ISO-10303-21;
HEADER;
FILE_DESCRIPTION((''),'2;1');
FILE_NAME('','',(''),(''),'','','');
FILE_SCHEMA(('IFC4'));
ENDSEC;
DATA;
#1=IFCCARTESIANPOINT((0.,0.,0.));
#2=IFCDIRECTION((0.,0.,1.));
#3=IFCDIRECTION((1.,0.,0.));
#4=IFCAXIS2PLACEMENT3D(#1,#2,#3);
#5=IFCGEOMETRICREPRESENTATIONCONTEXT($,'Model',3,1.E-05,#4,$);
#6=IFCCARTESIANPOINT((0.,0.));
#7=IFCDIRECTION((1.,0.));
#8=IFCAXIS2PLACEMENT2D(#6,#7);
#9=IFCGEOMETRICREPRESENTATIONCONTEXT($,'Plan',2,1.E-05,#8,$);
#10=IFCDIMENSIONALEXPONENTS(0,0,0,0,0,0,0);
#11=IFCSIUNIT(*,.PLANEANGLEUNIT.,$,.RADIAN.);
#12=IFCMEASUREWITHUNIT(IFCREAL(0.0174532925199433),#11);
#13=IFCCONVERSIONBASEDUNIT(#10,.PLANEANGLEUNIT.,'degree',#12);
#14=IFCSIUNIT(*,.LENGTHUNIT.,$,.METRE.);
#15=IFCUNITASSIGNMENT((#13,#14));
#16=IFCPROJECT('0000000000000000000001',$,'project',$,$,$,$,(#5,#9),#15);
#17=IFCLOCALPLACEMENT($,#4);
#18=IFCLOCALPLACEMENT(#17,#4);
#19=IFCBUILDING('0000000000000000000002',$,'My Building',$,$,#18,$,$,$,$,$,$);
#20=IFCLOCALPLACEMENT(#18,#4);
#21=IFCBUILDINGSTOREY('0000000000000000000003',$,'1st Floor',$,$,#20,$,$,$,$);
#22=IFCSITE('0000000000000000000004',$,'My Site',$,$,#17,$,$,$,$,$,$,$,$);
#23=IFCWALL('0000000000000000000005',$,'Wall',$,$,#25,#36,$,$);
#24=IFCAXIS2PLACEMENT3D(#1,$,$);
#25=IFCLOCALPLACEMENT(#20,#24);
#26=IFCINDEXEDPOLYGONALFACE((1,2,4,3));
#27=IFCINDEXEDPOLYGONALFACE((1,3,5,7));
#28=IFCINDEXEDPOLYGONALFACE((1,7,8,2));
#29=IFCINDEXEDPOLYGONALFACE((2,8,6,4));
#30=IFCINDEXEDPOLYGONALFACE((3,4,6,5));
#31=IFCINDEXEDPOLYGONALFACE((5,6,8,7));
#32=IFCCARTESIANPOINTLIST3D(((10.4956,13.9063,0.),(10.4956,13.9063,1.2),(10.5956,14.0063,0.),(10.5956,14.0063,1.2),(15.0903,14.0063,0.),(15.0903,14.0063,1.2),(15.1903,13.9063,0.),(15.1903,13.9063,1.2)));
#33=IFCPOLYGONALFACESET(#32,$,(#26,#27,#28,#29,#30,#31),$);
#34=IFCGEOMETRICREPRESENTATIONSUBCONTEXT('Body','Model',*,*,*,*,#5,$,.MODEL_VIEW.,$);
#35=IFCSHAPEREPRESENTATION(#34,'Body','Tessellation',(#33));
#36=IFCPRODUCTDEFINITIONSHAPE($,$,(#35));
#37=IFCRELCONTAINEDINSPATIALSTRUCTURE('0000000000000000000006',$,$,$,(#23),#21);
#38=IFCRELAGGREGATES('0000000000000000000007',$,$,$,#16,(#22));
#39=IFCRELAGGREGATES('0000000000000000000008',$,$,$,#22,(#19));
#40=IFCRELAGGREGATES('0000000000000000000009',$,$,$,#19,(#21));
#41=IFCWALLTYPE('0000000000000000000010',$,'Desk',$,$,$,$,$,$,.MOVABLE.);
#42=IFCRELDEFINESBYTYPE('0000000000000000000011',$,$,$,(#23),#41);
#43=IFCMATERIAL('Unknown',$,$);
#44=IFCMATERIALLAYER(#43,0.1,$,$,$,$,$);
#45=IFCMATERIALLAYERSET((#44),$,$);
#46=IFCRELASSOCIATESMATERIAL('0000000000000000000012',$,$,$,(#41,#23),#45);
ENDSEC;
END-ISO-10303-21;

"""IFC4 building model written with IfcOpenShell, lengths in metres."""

from ifc_helpers import new_model, entity, si_unit, converted_unit, frame, origin_with_axes, origin_2d_with_axis, place, context, subcontext, project, spatial, line, indexed_curve, outline, extrude, material, layer, layer_set, layer_usage, type_object, element, save


model = new_model("IFC4")

# Units and contexts
model_context = context("Model", 3, precision=1e-05, world=origin_with_axes())
plan_context = context("Plan", 2, precision=1e-05, world=origin_2d_with_axis())
body_context_1 = subcontext(model_context, "Body", "Model", "MODEL_VIEW")
ifc_project = project(units=[converted_unit("PLANEANGLEUNIT", "degree", entity("IfcReal", 0.0174532925199433), si_unit("PLANEANGLEUNIT", "RADIAN"), dimensions=[0, 0, 0, 0, 0, 0, 0]), si_unit("LENGTHUNIT", "METRE")], contexts=[model_context, plan_context])

# Site, building, storey
site_placement = place(None, origin_with_axes())
site = spatial("IfcSite", under=ifc_project, at=site_placement, Name="My Site")
building_placement = place(site_placement, origin_with_axes())
building = spatial("IfcBuilding", under=site, at=building_placement, Name="My Building")
storey_placement = place(building_placement, origin_with_axes())
storey = spatial("IfcBuildingStorey", under=building, at=storey_placement, Name="1st Floor")

# Shared definitions
ifc_material = material(Name="Unknown")

# Wall
ifc_layer_1 = layer(ifc_material, 0.1)
ifc_layer_set_1 = layer_set([ifc_layer_1])
wall_type_1 = type_object("IfcWallType", Name="Desk", PredefinedType="MOVABLE", material=ifc_layer_set_1)
ifc_layer_usage_1 = layer_usage(ifc_layer_set_1, "AXIS2", "POSITIVE", 0.0)
wall_1_placement = place(storey_placement, frame((10.4956, 13.9063, 0.0), z_axis=(0.0, 0.0, 1.0), x_axis=(1.0, 0.000001, 0.0)))
element("IfcWall", 1, at=wall_1_placement, inside=storey, type_object=wall_type_1, material=ifc_layer_usage_1, Name="Wall", context=body_context_1, shape_type="SweptSolid", body=[
    extrude(outline(indexed_curve([(0.0, 0.0), (0.1, 0.1), (4.5947, 0.1), (4.6947, 0.0)], segments=[line(1, 2, 3, 4, 1)])), origin_with_axes(), (0.0, 0.0, 1.0), 1.2),
])

save(model, "model.ifc")
